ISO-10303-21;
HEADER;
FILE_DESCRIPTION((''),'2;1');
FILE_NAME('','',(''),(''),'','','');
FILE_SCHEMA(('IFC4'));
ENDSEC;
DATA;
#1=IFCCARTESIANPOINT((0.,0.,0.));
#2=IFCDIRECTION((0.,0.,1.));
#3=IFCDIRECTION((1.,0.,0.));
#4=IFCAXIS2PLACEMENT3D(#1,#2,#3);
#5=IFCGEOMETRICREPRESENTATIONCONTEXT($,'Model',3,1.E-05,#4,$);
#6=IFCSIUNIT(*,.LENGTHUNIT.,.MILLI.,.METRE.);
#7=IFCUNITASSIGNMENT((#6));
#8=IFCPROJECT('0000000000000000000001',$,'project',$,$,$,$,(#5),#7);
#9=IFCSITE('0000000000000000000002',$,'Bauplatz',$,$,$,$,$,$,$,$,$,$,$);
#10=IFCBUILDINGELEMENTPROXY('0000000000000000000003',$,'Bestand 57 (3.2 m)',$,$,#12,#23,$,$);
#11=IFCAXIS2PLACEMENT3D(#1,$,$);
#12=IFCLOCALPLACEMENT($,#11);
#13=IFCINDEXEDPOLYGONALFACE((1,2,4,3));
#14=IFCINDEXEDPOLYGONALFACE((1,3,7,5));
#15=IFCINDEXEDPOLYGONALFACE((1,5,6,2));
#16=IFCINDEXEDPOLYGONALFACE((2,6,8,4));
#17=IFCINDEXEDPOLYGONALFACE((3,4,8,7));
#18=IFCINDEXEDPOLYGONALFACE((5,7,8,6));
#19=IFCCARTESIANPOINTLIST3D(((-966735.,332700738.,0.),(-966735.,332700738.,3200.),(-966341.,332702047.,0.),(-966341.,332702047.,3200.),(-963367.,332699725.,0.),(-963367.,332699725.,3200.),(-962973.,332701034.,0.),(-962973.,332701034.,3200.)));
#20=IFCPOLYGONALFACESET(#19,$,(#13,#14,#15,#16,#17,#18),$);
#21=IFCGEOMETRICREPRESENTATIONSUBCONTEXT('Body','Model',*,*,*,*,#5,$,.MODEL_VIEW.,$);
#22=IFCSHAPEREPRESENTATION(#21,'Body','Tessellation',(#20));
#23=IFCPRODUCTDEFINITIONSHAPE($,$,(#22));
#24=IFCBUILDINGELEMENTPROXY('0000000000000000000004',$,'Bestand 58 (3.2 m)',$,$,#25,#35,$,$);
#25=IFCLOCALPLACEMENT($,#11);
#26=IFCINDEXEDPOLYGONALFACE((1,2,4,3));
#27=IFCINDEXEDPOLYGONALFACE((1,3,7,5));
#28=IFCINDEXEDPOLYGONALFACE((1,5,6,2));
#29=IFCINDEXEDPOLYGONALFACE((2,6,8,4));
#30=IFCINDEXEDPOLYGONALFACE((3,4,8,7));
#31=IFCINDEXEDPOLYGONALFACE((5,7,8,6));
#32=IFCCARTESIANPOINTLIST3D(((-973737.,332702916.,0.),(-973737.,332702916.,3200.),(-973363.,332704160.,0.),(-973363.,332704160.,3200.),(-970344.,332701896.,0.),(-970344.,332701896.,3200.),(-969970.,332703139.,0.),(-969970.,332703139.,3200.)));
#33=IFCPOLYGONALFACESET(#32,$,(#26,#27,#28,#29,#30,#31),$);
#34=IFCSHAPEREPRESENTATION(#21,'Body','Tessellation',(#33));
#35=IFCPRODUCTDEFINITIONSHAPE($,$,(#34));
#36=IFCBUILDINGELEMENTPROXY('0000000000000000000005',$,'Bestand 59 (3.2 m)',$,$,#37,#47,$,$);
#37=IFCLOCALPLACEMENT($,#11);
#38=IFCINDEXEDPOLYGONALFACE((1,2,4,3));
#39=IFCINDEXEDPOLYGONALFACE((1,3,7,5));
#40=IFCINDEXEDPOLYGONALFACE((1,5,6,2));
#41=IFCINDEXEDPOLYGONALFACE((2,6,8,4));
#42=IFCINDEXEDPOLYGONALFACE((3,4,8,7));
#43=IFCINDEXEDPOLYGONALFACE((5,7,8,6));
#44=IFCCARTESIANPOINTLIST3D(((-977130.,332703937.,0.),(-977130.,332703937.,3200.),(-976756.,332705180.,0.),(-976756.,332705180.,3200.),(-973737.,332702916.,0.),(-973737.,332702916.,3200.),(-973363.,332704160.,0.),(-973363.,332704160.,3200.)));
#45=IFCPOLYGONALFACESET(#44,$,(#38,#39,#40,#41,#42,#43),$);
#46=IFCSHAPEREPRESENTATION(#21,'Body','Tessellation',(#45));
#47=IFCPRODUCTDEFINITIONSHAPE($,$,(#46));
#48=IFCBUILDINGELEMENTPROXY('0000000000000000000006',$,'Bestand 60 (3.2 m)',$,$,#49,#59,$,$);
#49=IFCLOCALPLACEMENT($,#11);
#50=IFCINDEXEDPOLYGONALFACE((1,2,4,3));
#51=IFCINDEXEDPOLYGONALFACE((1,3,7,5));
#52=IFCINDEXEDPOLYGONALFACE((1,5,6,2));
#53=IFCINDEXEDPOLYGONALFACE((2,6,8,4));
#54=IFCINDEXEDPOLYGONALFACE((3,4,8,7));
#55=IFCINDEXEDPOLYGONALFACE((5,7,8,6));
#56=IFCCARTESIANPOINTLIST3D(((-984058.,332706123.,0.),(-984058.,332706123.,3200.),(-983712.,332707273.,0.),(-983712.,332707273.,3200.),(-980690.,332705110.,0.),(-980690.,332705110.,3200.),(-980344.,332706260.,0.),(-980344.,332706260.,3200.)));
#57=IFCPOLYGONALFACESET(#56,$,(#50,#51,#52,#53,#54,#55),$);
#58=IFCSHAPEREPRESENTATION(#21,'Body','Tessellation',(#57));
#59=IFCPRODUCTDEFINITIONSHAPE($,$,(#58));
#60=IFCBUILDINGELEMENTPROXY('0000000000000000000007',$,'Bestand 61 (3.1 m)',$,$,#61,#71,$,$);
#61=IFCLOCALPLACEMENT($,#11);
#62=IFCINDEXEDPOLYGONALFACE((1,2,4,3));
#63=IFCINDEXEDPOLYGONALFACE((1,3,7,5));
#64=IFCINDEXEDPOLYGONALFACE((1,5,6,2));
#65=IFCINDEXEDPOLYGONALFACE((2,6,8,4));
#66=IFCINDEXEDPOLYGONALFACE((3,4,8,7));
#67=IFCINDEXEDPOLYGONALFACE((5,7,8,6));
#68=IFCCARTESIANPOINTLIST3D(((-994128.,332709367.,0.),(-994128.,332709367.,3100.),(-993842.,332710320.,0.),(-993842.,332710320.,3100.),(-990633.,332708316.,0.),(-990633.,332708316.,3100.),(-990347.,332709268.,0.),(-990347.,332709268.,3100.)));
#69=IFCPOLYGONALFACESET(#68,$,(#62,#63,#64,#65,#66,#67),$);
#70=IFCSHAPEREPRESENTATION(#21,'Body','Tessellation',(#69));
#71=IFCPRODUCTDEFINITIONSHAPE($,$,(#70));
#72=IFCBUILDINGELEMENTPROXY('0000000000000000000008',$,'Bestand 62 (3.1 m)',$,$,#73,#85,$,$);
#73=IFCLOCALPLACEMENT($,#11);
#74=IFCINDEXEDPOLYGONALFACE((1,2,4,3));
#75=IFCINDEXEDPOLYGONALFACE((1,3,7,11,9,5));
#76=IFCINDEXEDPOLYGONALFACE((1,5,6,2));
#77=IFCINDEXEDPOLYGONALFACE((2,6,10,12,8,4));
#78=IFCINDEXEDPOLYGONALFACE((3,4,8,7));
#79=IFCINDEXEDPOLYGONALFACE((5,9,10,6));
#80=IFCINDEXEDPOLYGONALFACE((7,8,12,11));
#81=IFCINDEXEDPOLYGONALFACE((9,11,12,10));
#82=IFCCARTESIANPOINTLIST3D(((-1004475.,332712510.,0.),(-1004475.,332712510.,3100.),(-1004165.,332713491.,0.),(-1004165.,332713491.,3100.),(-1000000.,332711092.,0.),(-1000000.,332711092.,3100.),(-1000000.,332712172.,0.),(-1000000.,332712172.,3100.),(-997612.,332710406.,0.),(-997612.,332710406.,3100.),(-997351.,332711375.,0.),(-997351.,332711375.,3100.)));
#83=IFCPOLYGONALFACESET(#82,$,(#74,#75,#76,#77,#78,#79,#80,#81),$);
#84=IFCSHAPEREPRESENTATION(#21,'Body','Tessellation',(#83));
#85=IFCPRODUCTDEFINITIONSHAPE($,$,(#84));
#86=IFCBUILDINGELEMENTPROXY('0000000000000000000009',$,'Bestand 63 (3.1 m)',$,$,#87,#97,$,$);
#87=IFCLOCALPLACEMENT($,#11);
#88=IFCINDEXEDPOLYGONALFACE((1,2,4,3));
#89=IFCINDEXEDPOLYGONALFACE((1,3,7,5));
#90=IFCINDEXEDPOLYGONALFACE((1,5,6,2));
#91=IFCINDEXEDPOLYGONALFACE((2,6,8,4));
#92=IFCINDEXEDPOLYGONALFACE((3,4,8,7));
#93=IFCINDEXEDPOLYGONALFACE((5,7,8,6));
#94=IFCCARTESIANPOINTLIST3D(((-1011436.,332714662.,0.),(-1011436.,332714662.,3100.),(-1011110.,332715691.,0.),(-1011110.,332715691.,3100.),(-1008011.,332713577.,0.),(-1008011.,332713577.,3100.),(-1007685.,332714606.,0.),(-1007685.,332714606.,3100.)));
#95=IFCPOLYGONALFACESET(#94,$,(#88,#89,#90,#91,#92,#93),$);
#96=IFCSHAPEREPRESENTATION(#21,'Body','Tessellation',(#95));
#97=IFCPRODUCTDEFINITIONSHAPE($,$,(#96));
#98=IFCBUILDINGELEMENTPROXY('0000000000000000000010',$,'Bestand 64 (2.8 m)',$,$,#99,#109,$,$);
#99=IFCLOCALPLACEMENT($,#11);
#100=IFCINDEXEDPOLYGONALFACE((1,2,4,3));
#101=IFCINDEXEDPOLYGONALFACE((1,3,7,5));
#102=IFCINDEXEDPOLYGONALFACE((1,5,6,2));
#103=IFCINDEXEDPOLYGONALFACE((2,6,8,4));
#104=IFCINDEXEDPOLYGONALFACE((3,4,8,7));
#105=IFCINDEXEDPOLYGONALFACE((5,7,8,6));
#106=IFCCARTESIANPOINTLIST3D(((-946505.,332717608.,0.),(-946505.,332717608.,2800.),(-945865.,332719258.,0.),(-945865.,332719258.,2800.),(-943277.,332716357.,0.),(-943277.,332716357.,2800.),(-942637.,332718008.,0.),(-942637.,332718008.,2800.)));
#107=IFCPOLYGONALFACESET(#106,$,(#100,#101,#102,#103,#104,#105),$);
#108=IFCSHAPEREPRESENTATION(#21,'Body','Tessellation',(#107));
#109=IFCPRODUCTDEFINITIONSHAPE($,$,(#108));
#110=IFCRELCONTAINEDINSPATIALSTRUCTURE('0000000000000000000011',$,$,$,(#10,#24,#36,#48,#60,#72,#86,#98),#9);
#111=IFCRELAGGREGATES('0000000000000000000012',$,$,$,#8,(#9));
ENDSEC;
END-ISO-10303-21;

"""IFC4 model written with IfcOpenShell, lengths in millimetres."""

from ifc_helpers import new_model, si_unit, origin_with_axes, place, context, subcontext, project, spatial, indexed_curve, outline, extrude, element, save


model = new_model("IFC4")

# Units and contexts
model_context = context("Model", 3, precision=1e-05, world=origin_with_axes())
body_context = subcontext(model_context, "Body", "Model", "MODEL_VIEW")
ifc_project = project(units=[si_unit("LENGTHUNIT", "METRE", prefix="MILLI")], contexts=[model_context])

# Site
site = spatial("IfcSite", under=ifc_project, Name="Bauplatz")

# Building element proxies
proxy_1_placement = place(None, origin_with_axes())
element("IfcBuildingElementProxy", 1, at=proxy_1_placement, inside=site, Name="Bestand 57 (3.2 m)", context=body_context, shape_type="SweptSolid", body=[
    extrude(outline(indexed_curve([(-962973.0, 332701034.0), (-966341.0, 332702047.0), (-966735.0, 332700738.0), (-963367.0, 332699725.0)])), None, (0.0, 0.0, 1.0), 3200.0),
])
proxy_2_placement = place(None, origin_with_axes())
element("IfcBuildingElementProxy", 2, at=proxy_2_placement, inside=site, Name="Bestand 58 (3.2 m)", context=body_context, shape_type="SweptSolid", body=[
    extrude(outline(indexed_curve([(-969970.0, 332703139.0), (-973363.0, 332704160.0), (-973737.0, 332702916.0), (-970344.0, 332701896.0)])), None, (0.0, 0.0, 1.0), 3200.0),
])
proxy_3_placement = place(None, origin_with_axes())
element("IfcBuildingElementProxy", 3, at=proxy_3_placement, inside=site, Name="Bestand 59 (3.2 m)", context=body_context, shape_type="SweptSolid", body=[
    extrude(outline(indexed_curve([(-973363.0, 332704160.0), (-976756.0, 332705180.0), (-977130.0, 332703937.0), (-973737.0, 332702916.0)])), None, (0.0, 0.0, 1.0), 3200.0),
])
proxy_4_placement = place(None, origin_with_axes())
element("IfcBuildingElementProxy", 4, at=proxy_4_placement, inside=site, Name="Bestand 60 (3.2 m)", context=body_context, shape_type="SweptSolid", body=[
    extrude(outline(indexed_curve([(-980344.0, 332706260.0), (-983712.0, 332707273.0), (-984058.0, 332706123.0), (-980690.0, 332705110.0)])), None, (0.0, 0.0, 1.0), 3200.0),
])
proxy_5_placement = place(None, origin_with_axes())
element("IfcBuildingElementProxy", 5, at=proxy_5_placement, inside=site, Name="Bestand 61 (3.1 m)", context=body_context, shape_type="SweptSolid", body=[
    extrude(outline(indexed_curve([(-990347.0, 332709268.0), (-993842.0, 332710320.0), (-994128.0, 332709367.0), (-990633.0, 332708316.0)])), None, (0.0, 0.0, 1.0), 3100.0),
])
proxy_6_placement = place(None, origin_with_axes())
element("IfcBuildingElementProxy", 6, at=proxy_6_placement, inside=site, Name="Bestand 62 (3.1 m)", context=body_context, shape_type="SweptSolid", body=[
    extrude(outline(indexed_curve([(-1000000.0, 332712172.0), (-1004165.0, 332713491.0), (-1004475.0, 332712510.0), (-1000000.0, 332711092.0), (-997612.0, 332710406.0), (-997351.0, 332711375.0)])), None, (0.0, 0.0, 1.0), 3100.0),
])
proxy_7_placement = place(None, origin_with_axes())
element("IfcBuildingElementProxy", 7, at=proxy_7_placement, inside=site, Name="Bestand 63 (3.1 m)", context=body_context, shape_type="SweptSolid", body=[
    extrude(outline(indexed_curve([(-1007685.0, 332714606.0), (-1011110.0, 332715691.0), (-1011436.0, 332714662.0), (-1008011.0, 332713577.0)])), None, (0.0, 0.0, 1.0), 3100.0),
])
proxy_8_placement = place(None, origin_with_axes())
element("IfcBuildingElementProxy", 8, at=proxy_8_placement, inside=site, Name="Bestand 64 (2.8 m)", context=body_context, shape_type="SweptSolid", body=[
    extrude(outline(indexed_curve([(-942637.0, 332718008.0), (-945865.0, 332719258.0), (-946505.0, 332717608.0), (-943277.0, 332716357.0)])), None, (0.0, 0.0, 1.0), 2800.0),
])

save(model, "model.ifc")
